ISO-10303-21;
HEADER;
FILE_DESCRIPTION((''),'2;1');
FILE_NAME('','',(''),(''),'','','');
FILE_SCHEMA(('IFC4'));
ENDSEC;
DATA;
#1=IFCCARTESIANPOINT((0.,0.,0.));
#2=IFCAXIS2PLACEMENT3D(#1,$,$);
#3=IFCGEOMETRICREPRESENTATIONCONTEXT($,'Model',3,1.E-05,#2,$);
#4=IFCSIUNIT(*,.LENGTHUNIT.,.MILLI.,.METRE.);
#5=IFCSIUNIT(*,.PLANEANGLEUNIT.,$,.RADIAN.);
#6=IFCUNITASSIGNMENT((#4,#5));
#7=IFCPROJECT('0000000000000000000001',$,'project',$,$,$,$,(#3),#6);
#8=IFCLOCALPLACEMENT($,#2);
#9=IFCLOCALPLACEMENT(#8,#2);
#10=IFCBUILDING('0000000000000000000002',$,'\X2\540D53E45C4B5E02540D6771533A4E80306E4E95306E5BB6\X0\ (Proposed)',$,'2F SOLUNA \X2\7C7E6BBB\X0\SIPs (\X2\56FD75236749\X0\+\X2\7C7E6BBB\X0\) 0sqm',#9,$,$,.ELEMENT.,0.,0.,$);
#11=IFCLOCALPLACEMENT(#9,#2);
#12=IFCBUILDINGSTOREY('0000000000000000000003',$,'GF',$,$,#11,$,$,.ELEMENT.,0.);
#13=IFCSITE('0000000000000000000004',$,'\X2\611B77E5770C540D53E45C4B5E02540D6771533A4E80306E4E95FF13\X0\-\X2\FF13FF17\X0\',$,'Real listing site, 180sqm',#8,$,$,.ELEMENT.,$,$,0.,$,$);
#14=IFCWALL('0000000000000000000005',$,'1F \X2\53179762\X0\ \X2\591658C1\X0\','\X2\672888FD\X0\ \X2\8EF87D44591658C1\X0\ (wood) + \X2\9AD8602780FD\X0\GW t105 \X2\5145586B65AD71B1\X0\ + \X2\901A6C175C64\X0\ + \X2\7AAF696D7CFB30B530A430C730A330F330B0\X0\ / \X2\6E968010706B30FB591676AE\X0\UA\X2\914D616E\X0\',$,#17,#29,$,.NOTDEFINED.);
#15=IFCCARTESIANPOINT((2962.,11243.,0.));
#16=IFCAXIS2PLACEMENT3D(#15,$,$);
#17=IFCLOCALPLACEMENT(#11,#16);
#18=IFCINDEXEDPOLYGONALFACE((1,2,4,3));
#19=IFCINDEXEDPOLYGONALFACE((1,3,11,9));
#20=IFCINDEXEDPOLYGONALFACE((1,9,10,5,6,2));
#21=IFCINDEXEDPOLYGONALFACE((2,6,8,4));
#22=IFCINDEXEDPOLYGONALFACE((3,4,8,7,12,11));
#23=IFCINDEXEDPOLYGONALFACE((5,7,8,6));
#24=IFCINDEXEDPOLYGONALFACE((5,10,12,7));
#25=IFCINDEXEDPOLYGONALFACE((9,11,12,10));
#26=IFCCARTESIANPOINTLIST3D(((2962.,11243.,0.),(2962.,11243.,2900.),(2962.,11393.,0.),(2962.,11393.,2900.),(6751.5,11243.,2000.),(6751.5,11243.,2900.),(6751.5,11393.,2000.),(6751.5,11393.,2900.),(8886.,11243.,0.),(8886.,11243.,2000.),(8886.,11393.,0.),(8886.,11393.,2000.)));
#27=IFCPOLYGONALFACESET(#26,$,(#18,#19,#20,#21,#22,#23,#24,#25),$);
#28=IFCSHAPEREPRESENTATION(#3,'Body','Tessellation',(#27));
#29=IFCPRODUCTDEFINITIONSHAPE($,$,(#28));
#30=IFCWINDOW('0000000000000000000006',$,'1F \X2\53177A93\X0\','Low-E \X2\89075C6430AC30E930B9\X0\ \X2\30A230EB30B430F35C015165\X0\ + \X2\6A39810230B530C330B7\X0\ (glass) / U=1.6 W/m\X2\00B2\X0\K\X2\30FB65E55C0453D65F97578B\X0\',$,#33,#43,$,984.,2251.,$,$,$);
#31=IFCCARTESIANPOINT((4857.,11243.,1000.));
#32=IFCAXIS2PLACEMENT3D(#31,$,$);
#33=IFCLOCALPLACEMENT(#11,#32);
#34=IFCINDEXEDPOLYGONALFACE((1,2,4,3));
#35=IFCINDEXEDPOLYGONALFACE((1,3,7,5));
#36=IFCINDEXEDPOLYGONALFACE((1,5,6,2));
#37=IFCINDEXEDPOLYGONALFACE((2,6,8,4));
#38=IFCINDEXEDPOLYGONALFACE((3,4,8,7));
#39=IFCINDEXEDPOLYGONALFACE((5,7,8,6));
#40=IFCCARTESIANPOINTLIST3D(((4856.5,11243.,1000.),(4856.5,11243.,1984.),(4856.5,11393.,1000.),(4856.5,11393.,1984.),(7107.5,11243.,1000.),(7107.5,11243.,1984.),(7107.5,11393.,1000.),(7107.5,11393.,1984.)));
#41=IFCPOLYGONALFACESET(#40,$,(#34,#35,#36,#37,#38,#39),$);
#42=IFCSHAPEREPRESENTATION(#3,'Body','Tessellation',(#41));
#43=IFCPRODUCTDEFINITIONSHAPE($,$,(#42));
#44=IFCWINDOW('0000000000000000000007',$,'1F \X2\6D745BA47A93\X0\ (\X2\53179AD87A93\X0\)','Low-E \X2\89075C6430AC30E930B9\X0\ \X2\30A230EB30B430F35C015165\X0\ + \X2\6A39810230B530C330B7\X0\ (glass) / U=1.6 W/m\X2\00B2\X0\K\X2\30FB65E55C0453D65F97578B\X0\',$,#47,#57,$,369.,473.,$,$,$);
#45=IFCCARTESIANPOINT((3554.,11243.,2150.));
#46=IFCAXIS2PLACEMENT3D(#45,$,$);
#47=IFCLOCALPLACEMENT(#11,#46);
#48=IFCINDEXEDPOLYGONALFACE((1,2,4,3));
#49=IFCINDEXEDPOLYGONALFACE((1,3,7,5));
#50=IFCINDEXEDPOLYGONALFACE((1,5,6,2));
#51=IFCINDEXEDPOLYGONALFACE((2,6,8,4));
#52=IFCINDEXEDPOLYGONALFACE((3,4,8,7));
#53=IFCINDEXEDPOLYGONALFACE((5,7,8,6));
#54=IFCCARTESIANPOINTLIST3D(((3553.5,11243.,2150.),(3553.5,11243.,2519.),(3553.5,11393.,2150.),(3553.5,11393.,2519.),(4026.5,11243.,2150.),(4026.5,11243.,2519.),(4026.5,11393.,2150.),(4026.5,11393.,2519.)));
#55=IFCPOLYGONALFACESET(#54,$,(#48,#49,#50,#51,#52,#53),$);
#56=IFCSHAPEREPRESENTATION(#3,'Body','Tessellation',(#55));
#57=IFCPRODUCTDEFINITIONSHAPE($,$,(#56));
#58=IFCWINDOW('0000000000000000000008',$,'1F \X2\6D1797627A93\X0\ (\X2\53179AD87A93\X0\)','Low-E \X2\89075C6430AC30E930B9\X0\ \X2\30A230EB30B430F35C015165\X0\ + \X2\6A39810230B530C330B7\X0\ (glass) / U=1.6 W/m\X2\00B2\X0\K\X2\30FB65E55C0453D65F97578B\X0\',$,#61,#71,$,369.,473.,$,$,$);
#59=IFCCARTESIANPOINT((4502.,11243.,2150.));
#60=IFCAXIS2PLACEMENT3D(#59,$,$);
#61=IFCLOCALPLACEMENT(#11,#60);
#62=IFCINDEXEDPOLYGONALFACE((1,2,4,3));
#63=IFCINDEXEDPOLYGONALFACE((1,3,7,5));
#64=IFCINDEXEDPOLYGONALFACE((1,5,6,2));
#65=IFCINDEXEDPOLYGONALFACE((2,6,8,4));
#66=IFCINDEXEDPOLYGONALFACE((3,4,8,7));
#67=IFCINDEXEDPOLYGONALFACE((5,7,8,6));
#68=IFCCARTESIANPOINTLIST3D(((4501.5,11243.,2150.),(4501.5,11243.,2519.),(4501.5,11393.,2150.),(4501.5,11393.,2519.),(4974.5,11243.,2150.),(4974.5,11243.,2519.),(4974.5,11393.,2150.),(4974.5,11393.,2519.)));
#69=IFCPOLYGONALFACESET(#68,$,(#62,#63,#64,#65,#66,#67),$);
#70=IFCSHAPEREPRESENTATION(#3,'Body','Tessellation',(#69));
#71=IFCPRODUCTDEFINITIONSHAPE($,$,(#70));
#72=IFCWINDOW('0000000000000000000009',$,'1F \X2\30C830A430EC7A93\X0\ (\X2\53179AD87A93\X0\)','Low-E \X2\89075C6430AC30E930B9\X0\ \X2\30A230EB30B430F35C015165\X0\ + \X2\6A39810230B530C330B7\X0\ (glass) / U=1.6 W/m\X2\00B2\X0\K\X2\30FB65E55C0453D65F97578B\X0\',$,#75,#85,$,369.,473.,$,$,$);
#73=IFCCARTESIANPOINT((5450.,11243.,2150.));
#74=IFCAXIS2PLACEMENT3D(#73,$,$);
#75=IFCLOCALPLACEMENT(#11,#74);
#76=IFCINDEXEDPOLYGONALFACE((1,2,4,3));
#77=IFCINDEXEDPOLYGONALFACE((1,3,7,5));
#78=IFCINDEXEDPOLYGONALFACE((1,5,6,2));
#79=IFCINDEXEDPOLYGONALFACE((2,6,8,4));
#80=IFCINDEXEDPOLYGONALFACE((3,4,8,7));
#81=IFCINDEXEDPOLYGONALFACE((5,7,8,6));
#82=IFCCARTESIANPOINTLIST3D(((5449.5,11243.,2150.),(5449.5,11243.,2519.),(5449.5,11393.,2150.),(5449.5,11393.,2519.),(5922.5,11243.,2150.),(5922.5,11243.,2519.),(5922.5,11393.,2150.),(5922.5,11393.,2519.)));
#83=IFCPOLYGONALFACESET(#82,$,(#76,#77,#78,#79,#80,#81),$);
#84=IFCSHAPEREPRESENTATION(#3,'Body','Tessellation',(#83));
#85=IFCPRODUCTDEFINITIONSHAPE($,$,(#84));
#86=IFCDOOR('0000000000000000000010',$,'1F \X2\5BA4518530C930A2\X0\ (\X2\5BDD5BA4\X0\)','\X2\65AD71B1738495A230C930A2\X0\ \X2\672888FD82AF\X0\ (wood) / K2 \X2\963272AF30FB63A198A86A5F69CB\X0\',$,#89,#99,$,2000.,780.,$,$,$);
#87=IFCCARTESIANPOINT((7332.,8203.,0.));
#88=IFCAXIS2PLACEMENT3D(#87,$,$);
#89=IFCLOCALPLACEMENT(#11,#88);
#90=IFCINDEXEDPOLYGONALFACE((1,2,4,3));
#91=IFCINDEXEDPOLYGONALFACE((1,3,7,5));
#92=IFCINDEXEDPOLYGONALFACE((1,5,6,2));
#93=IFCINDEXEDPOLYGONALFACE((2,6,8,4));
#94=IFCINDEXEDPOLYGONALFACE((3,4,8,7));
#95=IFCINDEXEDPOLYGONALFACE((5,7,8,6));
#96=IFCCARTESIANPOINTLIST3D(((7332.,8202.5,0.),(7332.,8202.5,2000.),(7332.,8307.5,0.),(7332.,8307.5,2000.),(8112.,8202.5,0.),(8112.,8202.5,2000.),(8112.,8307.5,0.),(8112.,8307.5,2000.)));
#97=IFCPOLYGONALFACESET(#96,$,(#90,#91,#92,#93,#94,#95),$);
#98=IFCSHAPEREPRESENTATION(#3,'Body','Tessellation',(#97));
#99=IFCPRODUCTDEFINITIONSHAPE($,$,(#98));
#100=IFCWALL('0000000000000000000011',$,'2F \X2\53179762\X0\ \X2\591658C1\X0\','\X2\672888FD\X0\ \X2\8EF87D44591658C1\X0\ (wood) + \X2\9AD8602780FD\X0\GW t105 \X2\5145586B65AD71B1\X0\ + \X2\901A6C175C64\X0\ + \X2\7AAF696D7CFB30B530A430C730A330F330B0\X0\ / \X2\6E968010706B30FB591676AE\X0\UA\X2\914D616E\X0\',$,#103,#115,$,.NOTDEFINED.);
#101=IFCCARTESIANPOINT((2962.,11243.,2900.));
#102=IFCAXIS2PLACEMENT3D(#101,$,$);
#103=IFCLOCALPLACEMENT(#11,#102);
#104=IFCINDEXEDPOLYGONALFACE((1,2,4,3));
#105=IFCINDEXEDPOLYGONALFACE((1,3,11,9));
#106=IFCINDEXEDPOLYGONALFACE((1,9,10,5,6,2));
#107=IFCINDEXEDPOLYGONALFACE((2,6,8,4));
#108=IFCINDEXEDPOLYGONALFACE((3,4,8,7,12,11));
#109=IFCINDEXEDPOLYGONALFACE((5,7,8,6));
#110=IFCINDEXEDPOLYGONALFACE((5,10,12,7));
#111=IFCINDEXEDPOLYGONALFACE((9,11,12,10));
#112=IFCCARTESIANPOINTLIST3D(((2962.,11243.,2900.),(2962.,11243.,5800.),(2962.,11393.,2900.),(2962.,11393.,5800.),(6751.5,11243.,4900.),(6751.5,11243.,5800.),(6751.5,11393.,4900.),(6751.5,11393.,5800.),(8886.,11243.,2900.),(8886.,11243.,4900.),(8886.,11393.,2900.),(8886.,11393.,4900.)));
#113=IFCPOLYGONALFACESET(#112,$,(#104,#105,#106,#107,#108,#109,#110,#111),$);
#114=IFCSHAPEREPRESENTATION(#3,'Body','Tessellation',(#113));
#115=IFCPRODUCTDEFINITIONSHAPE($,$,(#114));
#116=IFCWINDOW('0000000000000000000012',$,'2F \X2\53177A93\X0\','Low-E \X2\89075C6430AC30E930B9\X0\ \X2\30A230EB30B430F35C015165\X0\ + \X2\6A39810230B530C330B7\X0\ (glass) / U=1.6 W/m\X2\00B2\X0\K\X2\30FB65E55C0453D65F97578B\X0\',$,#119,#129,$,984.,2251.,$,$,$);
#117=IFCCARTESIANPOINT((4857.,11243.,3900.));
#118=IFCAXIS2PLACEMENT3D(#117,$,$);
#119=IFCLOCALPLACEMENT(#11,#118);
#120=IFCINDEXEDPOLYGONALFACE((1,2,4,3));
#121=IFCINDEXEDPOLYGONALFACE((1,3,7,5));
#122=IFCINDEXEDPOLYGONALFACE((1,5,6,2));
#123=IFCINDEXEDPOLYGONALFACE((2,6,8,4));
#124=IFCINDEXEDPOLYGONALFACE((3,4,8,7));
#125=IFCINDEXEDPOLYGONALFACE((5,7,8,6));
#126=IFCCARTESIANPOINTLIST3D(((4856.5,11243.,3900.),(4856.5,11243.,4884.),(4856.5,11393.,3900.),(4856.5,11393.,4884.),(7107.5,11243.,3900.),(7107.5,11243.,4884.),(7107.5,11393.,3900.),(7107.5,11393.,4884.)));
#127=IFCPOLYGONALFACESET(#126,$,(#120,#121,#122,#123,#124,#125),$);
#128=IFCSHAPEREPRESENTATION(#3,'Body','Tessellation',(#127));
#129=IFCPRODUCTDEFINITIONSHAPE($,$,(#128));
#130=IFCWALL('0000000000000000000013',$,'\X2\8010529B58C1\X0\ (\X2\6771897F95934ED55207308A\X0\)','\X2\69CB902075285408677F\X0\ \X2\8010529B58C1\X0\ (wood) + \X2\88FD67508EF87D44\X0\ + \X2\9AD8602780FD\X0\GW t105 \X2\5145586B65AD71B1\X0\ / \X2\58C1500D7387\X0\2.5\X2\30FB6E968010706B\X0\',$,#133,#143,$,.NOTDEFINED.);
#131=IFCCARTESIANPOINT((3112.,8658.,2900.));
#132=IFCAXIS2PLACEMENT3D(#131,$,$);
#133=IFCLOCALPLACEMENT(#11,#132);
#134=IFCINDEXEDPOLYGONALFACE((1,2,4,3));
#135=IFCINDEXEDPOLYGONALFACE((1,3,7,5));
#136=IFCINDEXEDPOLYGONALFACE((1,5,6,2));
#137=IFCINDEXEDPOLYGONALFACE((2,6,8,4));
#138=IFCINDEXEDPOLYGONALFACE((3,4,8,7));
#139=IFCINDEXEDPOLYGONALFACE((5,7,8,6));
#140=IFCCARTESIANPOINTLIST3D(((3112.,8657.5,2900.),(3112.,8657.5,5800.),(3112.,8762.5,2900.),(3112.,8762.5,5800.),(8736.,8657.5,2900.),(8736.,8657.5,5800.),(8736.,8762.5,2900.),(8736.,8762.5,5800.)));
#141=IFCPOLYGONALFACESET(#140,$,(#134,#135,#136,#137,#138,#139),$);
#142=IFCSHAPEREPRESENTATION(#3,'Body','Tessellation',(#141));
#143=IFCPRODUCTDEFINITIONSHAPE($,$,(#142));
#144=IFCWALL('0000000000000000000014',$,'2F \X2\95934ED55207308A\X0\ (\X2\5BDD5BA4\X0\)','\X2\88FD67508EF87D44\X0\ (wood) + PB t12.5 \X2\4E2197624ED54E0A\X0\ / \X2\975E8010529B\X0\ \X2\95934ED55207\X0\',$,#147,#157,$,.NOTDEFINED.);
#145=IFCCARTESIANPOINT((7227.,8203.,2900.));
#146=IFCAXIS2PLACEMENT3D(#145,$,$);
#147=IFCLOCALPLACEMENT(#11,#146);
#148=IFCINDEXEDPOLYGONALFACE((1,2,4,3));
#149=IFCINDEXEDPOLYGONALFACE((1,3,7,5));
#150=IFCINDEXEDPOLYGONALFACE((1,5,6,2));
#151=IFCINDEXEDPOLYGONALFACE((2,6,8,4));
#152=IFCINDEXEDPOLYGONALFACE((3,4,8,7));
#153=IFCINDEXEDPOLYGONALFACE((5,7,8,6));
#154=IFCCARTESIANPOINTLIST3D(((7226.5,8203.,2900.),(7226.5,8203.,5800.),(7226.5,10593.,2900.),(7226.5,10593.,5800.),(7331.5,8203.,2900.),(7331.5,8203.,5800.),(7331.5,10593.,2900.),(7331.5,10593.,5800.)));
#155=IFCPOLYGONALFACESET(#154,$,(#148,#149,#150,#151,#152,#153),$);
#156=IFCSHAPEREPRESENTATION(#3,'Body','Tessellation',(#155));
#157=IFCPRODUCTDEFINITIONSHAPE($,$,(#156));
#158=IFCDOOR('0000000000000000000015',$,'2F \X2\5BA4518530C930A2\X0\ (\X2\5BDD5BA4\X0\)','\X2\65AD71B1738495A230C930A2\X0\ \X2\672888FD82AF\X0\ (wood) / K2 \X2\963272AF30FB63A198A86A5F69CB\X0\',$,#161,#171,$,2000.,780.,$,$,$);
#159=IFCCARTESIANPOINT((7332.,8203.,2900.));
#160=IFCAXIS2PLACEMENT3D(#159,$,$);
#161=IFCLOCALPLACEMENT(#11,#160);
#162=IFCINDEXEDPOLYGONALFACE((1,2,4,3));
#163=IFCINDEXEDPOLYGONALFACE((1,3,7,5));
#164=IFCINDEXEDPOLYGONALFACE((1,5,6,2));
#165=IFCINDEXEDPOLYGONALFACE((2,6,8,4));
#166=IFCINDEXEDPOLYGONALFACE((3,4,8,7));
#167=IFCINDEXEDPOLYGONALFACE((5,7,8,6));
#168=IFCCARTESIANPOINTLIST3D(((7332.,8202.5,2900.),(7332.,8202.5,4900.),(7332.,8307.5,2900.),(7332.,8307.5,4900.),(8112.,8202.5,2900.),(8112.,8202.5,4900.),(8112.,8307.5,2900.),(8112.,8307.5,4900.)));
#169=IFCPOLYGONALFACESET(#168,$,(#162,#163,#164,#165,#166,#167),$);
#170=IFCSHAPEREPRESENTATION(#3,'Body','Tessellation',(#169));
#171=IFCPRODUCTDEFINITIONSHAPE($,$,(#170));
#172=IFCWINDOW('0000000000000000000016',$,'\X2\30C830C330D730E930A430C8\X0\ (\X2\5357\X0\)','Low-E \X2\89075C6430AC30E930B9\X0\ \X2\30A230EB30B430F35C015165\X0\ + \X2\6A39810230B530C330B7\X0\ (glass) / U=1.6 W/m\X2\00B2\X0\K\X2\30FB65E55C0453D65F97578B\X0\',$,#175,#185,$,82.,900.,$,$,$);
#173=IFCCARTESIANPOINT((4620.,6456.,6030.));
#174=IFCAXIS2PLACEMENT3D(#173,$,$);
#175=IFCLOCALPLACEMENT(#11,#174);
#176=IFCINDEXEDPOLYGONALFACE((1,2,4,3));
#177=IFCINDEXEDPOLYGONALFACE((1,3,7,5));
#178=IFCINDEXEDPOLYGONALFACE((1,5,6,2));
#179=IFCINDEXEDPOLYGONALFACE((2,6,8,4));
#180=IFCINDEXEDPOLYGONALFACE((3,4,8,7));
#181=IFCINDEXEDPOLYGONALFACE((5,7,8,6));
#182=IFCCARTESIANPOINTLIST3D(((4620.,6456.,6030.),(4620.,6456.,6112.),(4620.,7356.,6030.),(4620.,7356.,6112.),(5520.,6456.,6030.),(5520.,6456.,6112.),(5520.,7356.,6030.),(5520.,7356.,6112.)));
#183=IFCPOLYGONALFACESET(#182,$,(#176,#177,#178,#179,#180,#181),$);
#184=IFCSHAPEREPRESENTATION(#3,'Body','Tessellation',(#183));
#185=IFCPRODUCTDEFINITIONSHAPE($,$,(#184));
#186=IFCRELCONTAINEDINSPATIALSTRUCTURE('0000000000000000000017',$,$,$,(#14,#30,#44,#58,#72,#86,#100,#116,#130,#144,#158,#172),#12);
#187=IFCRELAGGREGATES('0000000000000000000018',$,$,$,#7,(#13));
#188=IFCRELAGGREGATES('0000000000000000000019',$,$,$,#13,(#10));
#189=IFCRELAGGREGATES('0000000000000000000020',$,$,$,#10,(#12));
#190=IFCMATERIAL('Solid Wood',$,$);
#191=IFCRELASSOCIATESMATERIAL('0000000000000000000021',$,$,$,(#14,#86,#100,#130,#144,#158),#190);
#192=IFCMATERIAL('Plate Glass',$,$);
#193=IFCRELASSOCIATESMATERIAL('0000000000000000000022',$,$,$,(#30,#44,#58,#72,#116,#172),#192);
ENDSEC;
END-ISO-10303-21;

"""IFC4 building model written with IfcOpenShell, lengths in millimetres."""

from ifc_helpers import new_model, si_unit, frame, frame_2d, origin, place, context, project, spatial, rectangle, extrude, material, element, fill, save


model = new_model("IFC4")

# Units and contexts
model_context = context("Model", 3, precision=1e-05, world=origin())
ifc_project = project(units=[si_unit("LENGTHUNIT", "METRE", prefix="MILLI"), si_unit("PLANEANGLEUNIT", "RADIAN")], contexts=[model_context])

# Site, building, storey
site_placement = place(None, origin())
site = spatial("IfcSite", under=ifc_project, at=site_placement, Name="愛知県名古屋市名東区亀の井３-３７", ObjectType="Real listing site, 180sqm", CompositionType="ELEMENT", RefElevation=0.0)
building_placement = place(site_placement, origin())
building = spatial("IfcBuilding", under=site, at=building_placement, Name="名古屋市名東区亀の井の家 (Proposed)", ObjectType="2F SOLUNA 籾殻SIPs (国産杉+籾殻) 0sqm", CompositionType="ELEMENT", ElevationOfRefHeight=0.0, ElevationOfTerrain=0.0)
storey_placement = place(building_placement, origin())
storey = spatial("IfcBuildingStorey", under=building, at=storey_placement, Name="GF", CompositionType="ELEMENT", Elevation=0.0)

# Wall, openings, windows
ifc_material_1 = material(Name="Solid Wood")
wall_1_placement = place(storey_placement, frame((2962.0, 11243.0, 0.0)))
wall_1 = element("IfcWall", 1, at=wall_1_placement, inside=storey, material=ifc_material_1, Name="1F 北面 外壁", Description="木製 軸組外壁 (wood) + 高性能GW t105 充填断熱 + 通気層 + 窯業系サイディング / 準耐火・外皮UA配慮", PredefinedType="NOTDEFINED", context=model_context, shape_type="SweptSolid", body=[
    extrude(rectangle(XDim=5924.0, YDim=150.0, at=frame_2d((2962.0, 75.0))), frame((2962.0, 11243.0, 0.0)), (0.0, 0.0, 1.0), 2900.0),
])
opening_1_placement = place(storey_placement, frame((4857.0, 11243.0, 1000.0)))
opening_1 = element("IfcOpeningElement", 2, at=opening_1_placement, cuts=wall_1, PredefinedType="NOTDEFINED", context=model_context, shape_type="SweptSolid", body=[
    extrude(rectangle(XDim=2251.0, YDim=150.0, at=frame_2d((1125.0, 75.0))), frame((4857.0, 11243.0, 1000.0)), (0.0, 0.0, 1.0), 984.0),
])
opening_2_placement = place(storey_placement, frame((3554.0, 11243.0, 2150.0)))
opening_2 = element("IfcOpeningElement", 3, at=opening_2_placement, cuts=wall_1, PredefinedType="NOTDEFINED", context=model_context, shape_type="SweptSolid", body=[
    extrude(rectangle(XDim=473.0, YDim=150.0, at=frame_2d((236.0, 75.0))), frame((3554.0, 11243.0, 2150.0)), (0.0, 0.0, 1.0), 369.0),
])
opening_3_placement = place(storey_placement, frame((4502.0, 11243.0, 2150.0)))
opening_3 = element("IfcOpeningElement", 4, at=opening_3_placement, cuts=wall_1, PredefinedType="NOTDEFINED", context=model_context, shape_type="SweptSolid", body=[
    extrude(rectangle(XDim=473.0, YDim=150.0, at=frame_2d((236.0, 75.0))), frame((4502.0, 11243.0, 2150.0)), (0.0, 0.0, 1.0), 369.0),
])
opening_4_placement = place(storey_placement, frame((5450.0, 11243.0, 2150.0)))
opening_4 = element("IfcOpeningElement", 5, at=opening_4_placement, cuts=wall_1, PredefinedType="NOTDEFINED", context=model_context, shape_type="SweptSolid", body=[
    extrude(rectangle(XDim=473.0, YDim=150.0, at=frame_2d((236.0, 75.0))), frame((5450.0, 11243.0, 2150.0)), (0.0, 0.0, 1.0), 369.0),
])
ifc_material_2 = material(Name="Plate Glass")
window_1_placement = place(storey_placement, frame((4857.0, 11243.0, 1000.0)))
window_1 = element("IfcWindow", 6, at=window_1_placement, inside=storey, material=ifc_material_2, Name="1F 北窓", Description="Low-E 複層ガラス アルゴン封入 + 樹脂サッシ (glass) / U=1.6 W/m²K・日射取得型", OverallHeight=984.0, OverallWidth=2251.0, context=model_context, shape_type="SweptSolid", body=[
    extrude(rectangle(XDim=2251.0, YDim=150.0, at=frame_2d((1125.0, 75.0))), frame((4857.0, 11243.0, 1000.0)), (0.0, 0.0, 1.0), 984.0),
])
fill(opening_1, window_1)
window_2_placement = place(storey_placement, frame((3554.0, 11243.0, 2150.0)))
window_2 = element("IfcWindow", 7, at=window_2_placement, inside=storey, material=ifc_material_2, Name="1F 浴室窓 (北高窓)", Description="Low-E 複層ガラス アルゴン封入 + 樹脂サッシ (glass) / U=1.6 W/m²K・日射取得型", OverallHeight=369.0, OverallWidth=473.0, context=model_context, shape_type="SweptSolid", body=[
    extrude(rectangle(XDim=473.0, YDim=150.0, at=frame_2d((236.0, 75.0))), frame((3554.0, 11243.0, 2150.0)), (0.0, 0.0, 1.0), 369.0),
])
fill(opening_2, window_2)
window_3_placement = place(storey_placement, frame((4502.0, 11243.0, 2150.0)))
window_3 = element("IfcWindow", 8, at=window_3_placement, inside=storey, material=ifc_material_2, Name="1F 洗面窓 (北高窓)", Description="Low-E 複層ガラス アルゴン封入 + 樹脂サッシ (glass) / U=1.6 W/m²K・日射取得型", OverallHeight=369.0, OverallWidth=473.0, context=model_context, shape_type="SweptSolid", body=[
    extrude(rectangle(XDim=473.0, YDim=150.0, at=frame_2d((236.0, 75.0))), frame((4502.0, 11243.0, 2150.0)), (0.0, 0.0, 1.0), 369.0),
])
fill(opening_3, window_3)
window_4_placement = place(storey_placement, frame((5450.0, 11243.0, 2150.0)))
window_4 = element("IfcWindow", 9, at=window_4_placement, inside=storey, material=ifc_material_2, Name="1F トイレ窓 (北高窓)", Description="Low-E 複層ガラス アルゴン封入 + 樹脂サッシ (glass) / U=1.6 W/m²K・日射取得型", OverallHeight=369.0, OverallWidth=473.0, context=model_context, shape_type="SweptSolid", body=[
    extrude(rectangle(XDim=473.0, YDim=150.0, at=frame_2d((236.0, 75.0))), frame((5450.0, 11243.0, 2150.0)), (0.0, 0.0, 1.0), 369.0),
])
fill(opening_4, window_4)

# Door
door_1_placement = place(storey_placement, frame((7332.0, 8203.0, 0.0)))
element("IfcDoor", 10, at=door_1_placement, inside=storey, material=ifc_material_1, Name="1F 室内ドア (寝室)", Description="断熱玄関ドア 木製芯 (wood) / K2 防犯・採風機構", OverallHeight=2000.0, OverallWidth=780.0, context=model_context, shape_type="SweptSolid", body=[
    extrude(rectangle(XDim=780.0, YDim=105.0, at=frame_2d((390.0, 52.0))), frame((7332.0, 8203.0, 0.0)), (0.0, 0.0, 1.0), 2000.0),
])

# Wall, opening, window
wall_2_placement = place(storey_placement, frame((2962.0, 11243.0, 2900.0)))
wall_2 = element("IfcWall", 11, at=wall_2_placement, inside=storey, material=ifc_material_1, Name="2F 北面 外壁", Description="木製 軸組外壁 (wood) + 高性能GW t105 充填断熱 + 通気層 + 窯業系サイディング / 準耐火・外皮UA配慮", PredefinedType="NOTDEFINED", context=model_context, shape_type="SweptSolid", body=[
    extrude(rectangle(XDim=5924.0, YDim=150.0, at=frame_2d((2962.0, 75.0))), frame((2962.0, 11243.0, 2900.0)), (0.0, 0.0, 1.0), 2900.0),
])
opening_5_placement = place(storey_placement, frame((4857.0, 11243.0, 3900.0)))
opening_5 = element("IfcOpeningElement", 12, at=opening_5_placement, cuts=wall_2, PredefinedType="NOTDEFINED", context=model_context, shape_type="SweptSolid", body=[
    extrude(rectangle(XDim=2251.0, YDim=150.0, at=frame_2d((1125.0, 75.0))), frame((4857.0, 11243.0, 3900.0)), (0.0, 0.0, 1.0), 984.0),
])
window_5_placement = place(storey_placement, frame((4857.0, 11243.0, 3900.0)))
window_5 = element("IfcWindow", 13, at=window_5_placement, inside=storey, material=ifc_material_2, Name="2F 北窓", Description="Low-E 複層ガラス アルゴン封入 + 樹脂サッシ (glass) / U=1.6 W/m²K・日射取得型", OverallHeight=984.0, OverallWidth=2251.0, context=model_context, shape_type="SweptSolid", body=[
    extrude(rectangle(XDim=2251.0, YDim=150.0, at=frame_2d((1125.0, 75.0))), frame((4857.0, 11243.0, 3900.0)), (0.0, 0.0, 1.0), 984.0),
])
fill(opening_5, window_5)

# Walls
wall_3_placement = place(storey_placement, frame((3112.0, 8658.0, 2900.0)))
element("IfcWall", 14, at=wall_3_placement, inside=storey, material=ifc_material_1, Name="耐力壁 (東西間仕切り)", Description="構造用合板 耐力壁 (wood) + 製材軸組 + 高性能GW t105 充填断熱 / 壁倍率2.5・準耐火", PredefinedType="NOTDEFINED", context=model_context, shape_type="SweptSolid", body=[
    extrude(rectangle(XDim=5624.0, YDim=105.0, at=frame_2d((2812.0, 52.0))), frame((3112.0, 8658.0, 2900.0)), (0.0, 0.0, 1.0), 2900.0),
])
wall_4_placement = place(storey_placement, frame((7227.0, 8203.0, 2900.0)))
element("IfcWall", 15, at=wall_4_placement, inside=storey, material=ifc_material_1, Name="2F 間仕切り (寝室)", Description="製材軸組 (wood) + PB t12.5 両面仕上 / 非耐力 間仕切", PredefinedType="NOTDEFINED", context=model_context, shape_type="SweptSolid", body=[
    extrude(rectangle(XDim=105.0, YDim=2390.0, at=frame_2d((52.0, 1195.0))), frame((7227.0, 8203.0, 2900.0)), (0.0, 0.0, 1.0), 2900.0),
])

# Door
door_2_placement = place(storey_placement, frame((7332.0, 8203.0, 2900.0)))
element("IfcDoor", 16, at=door_2_placement, inside=storey, material=ifc_material_1, Name="2F 室内ドア (寝室)", Description="断熱玄関ドア 木製芯 (wood) / K2 防犯・採風機構", OverallHeight=2000.0, OverallWidth=780.0, context=model_context, shape_type="SweptSolid", body=[
    extrude(rectangle(XDim=780.0, YDim=105.0, at=frame_2d((390.0, 52.0))), frame((7332.0, 8203.0, 2900.0)), (0.0, 0.0, 1.0), 2000.0),
])

# Window
window_6_placement = place(storey_placement, frame((4620.0, 6456.0, 6030.0)))
element("IfcWindow", 17, at=window_6_placement, inside=storey, material=ifc_material_2, Name="トップライト (南)", Description="Low-E 複層ガラス アルゴン封入 + 樹脂サッシ (glass) / U=1.6 W/m²K・日射取得型", OverallHeight=82.0, OverallWidth=900.0, context=model_context, shape_type="SweptSolid", body=[
    extrude(rectangle(XDim=900.0, YDim=900.0, at=frame_2d((450.0, 450.0))), frame((4620.0, 6456.0, 6030.0)), (0.0, 0.0, 1.0), 82.0),
])

save(model, "model.ifc")
